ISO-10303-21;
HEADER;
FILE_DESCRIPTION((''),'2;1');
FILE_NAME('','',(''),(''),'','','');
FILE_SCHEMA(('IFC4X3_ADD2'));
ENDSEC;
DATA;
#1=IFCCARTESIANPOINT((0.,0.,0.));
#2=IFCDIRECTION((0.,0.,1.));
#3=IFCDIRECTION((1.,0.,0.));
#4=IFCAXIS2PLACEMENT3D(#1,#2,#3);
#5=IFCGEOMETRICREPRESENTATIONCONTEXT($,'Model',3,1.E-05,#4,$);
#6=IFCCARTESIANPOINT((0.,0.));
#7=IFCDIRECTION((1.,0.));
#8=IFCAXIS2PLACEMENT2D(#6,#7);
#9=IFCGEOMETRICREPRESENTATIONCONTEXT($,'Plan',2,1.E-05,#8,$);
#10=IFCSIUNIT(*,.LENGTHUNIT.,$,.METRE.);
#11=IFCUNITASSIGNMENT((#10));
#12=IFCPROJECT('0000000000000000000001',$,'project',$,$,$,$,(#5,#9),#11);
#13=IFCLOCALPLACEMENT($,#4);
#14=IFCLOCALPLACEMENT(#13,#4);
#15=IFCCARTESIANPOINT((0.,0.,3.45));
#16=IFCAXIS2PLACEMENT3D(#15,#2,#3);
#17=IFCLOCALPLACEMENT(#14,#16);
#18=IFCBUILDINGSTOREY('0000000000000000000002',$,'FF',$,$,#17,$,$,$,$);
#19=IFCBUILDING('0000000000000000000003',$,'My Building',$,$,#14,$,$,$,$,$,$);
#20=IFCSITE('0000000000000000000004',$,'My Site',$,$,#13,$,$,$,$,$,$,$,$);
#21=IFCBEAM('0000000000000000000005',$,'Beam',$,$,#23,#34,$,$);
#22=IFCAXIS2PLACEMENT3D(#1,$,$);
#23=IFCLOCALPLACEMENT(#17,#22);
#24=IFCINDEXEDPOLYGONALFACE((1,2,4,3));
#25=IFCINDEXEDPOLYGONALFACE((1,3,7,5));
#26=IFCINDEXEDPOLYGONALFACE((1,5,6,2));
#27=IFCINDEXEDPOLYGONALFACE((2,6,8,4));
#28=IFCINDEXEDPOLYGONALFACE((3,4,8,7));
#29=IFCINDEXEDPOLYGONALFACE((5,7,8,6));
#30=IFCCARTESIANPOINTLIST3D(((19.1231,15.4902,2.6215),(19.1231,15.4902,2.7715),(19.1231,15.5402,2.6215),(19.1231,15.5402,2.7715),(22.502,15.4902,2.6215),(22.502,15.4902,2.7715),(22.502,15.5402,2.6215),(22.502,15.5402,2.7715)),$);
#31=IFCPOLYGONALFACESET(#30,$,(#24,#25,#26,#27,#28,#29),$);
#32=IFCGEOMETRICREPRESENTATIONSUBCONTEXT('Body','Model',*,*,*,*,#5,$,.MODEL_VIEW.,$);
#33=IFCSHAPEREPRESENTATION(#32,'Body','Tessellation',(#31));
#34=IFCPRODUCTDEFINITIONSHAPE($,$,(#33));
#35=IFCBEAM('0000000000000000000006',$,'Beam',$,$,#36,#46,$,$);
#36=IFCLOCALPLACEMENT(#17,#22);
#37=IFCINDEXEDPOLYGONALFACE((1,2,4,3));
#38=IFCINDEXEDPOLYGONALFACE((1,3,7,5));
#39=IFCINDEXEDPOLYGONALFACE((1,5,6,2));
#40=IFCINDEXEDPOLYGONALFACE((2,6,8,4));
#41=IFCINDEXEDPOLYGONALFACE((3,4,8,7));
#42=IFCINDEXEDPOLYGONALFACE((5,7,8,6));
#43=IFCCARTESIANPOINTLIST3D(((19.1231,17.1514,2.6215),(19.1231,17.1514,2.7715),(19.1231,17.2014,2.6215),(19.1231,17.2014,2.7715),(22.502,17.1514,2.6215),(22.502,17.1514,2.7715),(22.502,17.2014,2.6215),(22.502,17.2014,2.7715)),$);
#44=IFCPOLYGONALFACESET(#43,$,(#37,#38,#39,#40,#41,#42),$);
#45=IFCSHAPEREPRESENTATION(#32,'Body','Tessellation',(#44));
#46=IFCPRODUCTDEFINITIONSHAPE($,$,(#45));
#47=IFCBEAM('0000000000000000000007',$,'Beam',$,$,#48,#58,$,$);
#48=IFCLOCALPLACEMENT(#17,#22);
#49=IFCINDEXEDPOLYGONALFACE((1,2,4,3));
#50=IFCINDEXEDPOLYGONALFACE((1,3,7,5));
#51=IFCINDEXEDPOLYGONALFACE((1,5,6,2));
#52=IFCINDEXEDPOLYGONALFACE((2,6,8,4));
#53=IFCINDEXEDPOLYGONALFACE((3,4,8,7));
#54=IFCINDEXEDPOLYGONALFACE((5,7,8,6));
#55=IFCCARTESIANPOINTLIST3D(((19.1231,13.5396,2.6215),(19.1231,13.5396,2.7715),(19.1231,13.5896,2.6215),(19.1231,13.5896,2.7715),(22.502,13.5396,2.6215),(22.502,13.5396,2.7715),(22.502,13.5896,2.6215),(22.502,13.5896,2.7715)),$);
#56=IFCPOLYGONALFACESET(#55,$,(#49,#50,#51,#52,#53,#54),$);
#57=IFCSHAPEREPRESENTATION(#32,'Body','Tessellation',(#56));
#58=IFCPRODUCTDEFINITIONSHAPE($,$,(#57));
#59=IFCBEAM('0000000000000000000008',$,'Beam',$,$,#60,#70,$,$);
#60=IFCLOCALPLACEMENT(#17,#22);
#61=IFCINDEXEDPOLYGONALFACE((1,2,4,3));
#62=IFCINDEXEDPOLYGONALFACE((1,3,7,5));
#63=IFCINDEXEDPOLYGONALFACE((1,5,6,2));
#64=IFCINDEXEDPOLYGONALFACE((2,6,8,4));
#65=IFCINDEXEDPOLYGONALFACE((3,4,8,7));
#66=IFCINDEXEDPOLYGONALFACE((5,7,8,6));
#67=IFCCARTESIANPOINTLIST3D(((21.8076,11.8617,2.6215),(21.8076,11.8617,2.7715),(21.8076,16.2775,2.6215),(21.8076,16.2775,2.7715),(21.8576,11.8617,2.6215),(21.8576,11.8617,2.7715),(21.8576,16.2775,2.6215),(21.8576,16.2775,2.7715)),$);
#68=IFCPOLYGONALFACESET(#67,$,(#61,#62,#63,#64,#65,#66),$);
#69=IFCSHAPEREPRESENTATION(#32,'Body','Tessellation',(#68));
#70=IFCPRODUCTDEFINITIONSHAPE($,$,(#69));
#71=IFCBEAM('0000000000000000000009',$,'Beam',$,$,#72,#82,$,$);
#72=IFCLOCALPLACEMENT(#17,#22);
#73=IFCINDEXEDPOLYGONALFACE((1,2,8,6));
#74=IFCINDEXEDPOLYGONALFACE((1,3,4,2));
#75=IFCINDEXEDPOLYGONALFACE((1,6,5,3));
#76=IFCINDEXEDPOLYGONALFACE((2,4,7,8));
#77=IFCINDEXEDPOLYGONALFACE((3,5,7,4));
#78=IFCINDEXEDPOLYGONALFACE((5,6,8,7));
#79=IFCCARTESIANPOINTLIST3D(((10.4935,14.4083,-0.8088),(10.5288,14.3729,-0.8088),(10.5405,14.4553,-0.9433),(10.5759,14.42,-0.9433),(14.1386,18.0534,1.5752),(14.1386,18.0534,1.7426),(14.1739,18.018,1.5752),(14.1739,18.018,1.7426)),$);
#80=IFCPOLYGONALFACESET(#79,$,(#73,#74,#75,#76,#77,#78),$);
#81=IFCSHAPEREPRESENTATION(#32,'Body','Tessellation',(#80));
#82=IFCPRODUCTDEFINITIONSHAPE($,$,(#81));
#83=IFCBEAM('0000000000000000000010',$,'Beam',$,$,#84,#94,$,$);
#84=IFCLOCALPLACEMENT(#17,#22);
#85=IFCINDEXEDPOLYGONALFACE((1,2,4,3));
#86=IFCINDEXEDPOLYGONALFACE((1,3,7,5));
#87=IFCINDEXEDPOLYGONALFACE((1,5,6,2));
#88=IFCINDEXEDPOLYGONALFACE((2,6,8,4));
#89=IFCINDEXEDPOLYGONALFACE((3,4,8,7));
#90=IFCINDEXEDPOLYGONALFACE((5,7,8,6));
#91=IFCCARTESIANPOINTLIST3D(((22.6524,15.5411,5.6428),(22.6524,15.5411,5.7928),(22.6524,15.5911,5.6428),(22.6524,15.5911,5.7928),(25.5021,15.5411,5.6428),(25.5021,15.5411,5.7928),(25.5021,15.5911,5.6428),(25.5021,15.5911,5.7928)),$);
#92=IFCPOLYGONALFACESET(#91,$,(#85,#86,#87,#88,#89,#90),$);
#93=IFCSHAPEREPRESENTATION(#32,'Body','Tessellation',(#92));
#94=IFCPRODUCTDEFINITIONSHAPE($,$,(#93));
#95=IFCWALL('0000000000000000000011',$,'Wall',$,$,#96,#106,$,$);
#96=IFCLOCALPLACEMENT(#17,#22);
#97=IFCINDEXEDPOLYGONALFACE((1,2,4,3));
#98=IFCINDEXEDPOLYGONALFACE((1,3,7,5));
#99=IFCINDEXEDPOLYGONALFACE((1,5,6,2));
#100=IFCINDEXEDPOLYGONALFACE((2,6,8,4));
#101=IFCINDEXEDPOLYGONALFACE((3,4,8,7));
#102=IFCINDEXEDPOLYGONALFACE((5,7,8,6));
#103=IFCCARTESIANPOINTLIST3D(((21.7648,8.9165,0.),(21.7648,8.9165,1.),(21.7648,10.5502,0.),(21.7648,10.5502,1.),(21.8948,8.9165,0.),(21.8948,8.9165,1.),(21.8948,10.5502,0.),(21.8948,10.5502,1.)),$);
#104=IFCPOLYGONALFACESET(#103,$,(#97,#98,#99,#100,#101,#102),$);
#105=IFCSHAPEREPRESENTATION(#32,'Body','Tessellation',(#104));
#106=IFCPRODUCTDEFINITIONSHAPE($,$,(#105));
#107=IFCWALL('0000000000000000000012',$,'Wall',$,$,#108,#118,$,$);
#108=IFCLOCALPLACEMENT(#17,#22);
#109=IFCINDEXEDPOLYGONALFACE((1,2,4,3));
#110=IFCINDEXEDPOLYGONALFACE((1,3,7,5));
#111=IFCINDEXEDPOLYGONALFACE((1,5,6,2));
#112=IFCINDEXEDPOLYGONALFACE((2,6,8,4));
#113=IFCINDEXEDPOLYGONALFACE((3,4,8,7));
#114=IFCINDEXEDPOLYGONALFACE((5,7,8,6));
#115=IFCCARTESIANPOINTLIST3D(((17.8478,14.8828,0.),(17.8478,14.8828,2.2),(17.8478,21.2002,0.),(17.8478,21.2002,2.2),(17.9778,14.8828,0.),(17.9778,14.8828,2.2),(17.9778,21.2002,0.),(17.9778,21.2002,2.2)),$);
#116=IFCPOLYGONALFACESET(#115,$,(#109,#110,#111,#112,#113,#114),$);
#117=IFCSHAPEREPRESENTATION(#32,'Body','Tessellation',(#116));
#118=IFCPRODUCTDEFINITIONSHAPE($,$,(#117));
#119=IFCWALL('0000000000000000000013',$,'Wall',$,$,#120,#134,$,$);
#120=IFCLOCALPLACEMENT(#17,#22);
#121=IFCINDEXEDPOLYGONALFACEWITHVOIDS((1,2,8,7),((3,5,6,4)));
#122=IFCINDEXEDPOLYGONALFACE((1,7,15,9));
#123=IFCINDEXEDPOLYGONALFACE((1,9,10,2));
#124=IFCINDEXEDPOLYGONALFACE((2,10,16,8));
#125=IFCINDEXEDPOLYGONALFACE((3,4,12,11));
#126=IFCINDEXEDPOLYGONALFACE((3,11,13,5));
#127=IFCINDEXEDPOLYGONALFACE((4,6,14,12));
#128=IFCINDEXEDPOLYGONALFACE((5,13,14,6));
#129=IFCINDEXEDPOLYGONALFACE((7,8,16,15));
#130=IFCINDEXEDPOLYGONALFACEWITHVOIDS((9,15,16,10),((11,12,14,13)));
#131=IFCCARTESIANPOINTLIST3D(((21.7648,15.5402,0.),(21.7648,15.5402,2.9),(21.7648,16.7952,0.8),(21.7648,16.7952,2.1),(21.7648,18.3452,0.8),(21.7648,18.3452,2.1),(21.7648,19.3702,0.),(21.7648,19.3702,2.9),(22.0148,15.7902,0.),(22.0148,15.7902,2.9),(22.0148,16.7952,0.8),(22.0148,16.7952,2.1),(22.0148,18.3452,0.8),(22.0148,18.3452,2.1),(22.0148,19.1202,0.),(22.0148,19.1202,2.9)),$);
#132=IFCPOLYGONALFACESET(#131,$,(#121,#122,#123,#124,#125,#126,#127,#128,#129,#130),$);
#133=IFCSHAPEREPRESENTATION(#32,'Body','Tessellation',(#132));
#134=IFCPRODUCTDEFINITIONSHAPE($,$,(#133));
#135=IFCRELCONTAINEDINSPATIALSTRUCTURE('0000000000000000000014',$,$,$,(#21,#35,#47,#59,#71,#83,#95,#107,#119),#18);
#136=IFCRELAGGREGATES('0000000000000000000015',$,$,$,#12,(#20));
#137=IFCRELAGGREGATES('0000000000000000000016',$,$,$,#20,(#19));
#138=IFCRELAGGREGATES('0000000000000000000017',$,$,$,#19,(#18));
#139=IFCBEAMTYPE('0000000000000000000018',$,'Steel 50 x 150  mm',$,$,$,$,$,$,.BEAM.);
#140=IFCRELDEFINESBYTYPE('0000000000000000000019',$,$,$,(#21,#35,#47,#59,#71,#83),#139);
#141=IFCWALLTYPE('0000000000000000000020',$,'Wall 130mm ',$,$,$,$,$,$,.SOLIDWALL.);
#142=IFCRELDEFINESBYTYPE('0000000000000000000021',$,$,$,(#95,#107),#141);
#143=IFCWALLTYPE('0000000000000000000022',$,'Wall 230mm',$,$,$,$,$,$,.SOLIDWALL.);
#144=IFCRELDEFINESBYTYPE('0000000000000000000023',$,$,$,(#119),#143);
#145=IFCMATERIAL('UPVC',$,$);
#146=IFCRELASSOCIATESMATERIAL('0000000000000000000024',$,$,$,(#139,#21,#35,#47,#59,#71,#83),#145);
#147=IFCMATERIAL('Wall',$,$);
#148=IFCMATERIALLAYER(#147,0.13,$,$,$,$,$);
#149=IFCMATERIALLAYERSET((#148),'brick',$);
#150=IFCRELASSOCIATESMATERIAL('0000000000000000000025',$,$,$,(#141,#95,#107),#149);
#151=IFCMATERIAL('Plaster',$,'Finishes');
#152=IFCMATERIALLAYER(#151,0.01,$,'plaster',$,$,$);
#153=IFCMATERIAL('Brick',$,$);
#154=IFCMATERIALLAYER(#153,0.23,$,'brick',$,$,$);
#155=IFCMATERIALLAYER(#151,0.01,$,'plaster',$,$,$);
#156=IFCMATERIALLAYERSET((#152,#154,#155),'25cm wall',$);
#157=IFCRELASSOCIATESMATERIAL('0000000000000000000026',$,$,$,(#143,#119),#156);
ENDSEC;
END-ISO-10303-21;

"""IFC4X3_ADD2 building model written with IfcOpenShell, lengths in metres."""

from ifc_helpers import new_model, si_unit, frame, origin_with_axes, origin_2d_with_axis, place, context, subcontext, project, spatial, line, indexed_curve, rectangle, outline, extrude, clip, halfspace, source, transform, mapped, material, layer, layer_set, layer_usage, material_profile, profile_set, profile_usage, type_object, element, save


model = new_model("IFC4X3_ADD2")

# Units and contexts
model_context = context("Model", 3, precision=1e-05, world=origin_with_axes())
plan_context = context("Plan", 2, precision=1e-05, world=origin_2d_with_axis())
body_context = subcontext(model_context, "Body", "Model", "MODEL_VIEW")
ifc_project = project(units=[si_unit("LENGTHUNIT", "METRE")], contexts=[model_context, plan_context])

# Site, building, storey
site_placement = place(None, origin_with_axes())
site = spatial("IfcSite", under=ifc_project, at=site_placement, Name="My Site")
building_placement = place(site_placement, origin_with_axes())
building = spatial("IfcBuilding", under=site, at=building_placement, Name="My Building")
storey_placement = place(building_placement, frame((0.0, 0.0, 3.45), z_axis=(0.0, 0.0, 1.0), x_axis=(1.0, 0.0, 0.0)))
storey = spatial("IfcBuildingStorey", under=building, at=storey_placement, Name="FF")

# Beams
ifc_material_1 = material(Name="UPVC")
ifc_material_profile = material_profile(ifc_material_1, rectangle(XDim=0.05, YDim=0.15))
ifc_profile_set = profile_set([ifc_material_profile])
beam_type = type_object("IfcBeamType", Name="Steel 50 x 150  mm", PredefinedType="BEAM", material=ifc_profile_set)
ifc_profile_usage_1 = profile_usage(ifc_profile_set)
beam_1_placement = place(storey_placement, frame((19.1231, 15.5152, 2.6965), z_axis=(1.0, 0.0, 0.0), x_axis=(0.0, 1.0, 0.0)))
element("IfcBeam", 1, at=beam_1_placement, inside=storey, type_object=beam_type, material=ifc_profile_usage_1, Name="Beam", context=body_context, shape_type="SweptSolid", body=[
    extrude(rectangle(XDim=0.05, YDim=0.15), origin_with_axes(), (0.0, 0.0, 1.0), 3.3789),
])
ifc_profile_usage_2 = profile_usage(ifc_profile_set)
beam_2_placement = place(storey_placement, frame((19.1231, 17.1764, 2.6965), z_axis=(1.0, 0.0, 0.0), x_axis=(0.0, 1.0, 0.0)))
element("IfcBeam", 2, at=beam_2_placement, inside=storey, type_object=beam_type, material=ifc_profile_usage_2, Name="Beam", context=body_context, shape_type="SweptSolid", body=[
    extrude(rectangle(XDim=0.05, YDim=0.15), origin_with_axes(), (0.0, 0.0, 1.0), 3.3789),
])
ifc_profile_usage_3 = profile_usage(ifc_profile_set)
beam_3_placement = place(storey_placement, frame((19.1231, 13.5646, 2.6965), z_axis=(1.0, 0.0, 0.0), x_axis=(0.0, 1.0, 0.0)))
element("IfcBeam", 3, at=beam_3_placement, inside=storey, type_object=beam_type, material=ifc_profile_usage_3, Name="Beam", context=body_context, shape_type="SweptSolid", body=[
    extrude(rectangle(XDim=0.05, YDim=0.15), origin_with_axes(), (0.0, 0.0, 1.0), 3.3789),
])
ifc_profile_usage_4 = profile_usage(ifc_profile_set)
beam_4_placement = place(storey_placement, frame((21.8326, 11.8617, 2.6965), z_axis=(0.0, 1.0, 0.0), x_axis=(-1.0, 0.0, 0.0)))
element("IfcBeam", 4, at=beam_4_placement, inside=storey, type_object=beam_type, material=ifc_profile_usage_4, Name="Beam", context=body_context, shape_type="SweptSolid", body=[
    extrude(rectangle(XDim=0.05, YDim=0.15), origin_with_axes(), (0.0, 0.0, 1.0), 4.4158),
])
ifc_profile_usage_5 = profile_usage(ifc_profile_set)
beam_5_placement = place(storey_placement, frame((10.5347, 14.4141, -0.8761), z_axis=(0.63373, 0.633729, 0.443593), x_axis=(-0.707106, 0.707107, 0.0)))
element("IfcBeam", 5, at=beam_5_placement, inside=storey, type_object=beam_type, material=ifc_profile_usage_5, Name="Beam", context=body_context, shape_type="Clipping", body=[
    clip(extrude(rectangle(XDim=0.05, YDim=0.15), origin_with_axes(), (0.0, 0.0, 1.0), 5.8647), halfspace(frame((5.1339, -2.2719, 4.5902), z_axis=(0.0, -0.443593, 0.896229), x_axis=(-1.0, 0.0, 0.0)), False)),
])
ifc_profile_usage_6 = profile_usage(ifc_profile_set)
beam_6_placement = place(storey_placement, frame((22.6524, 15.5661, 5.7178), z_axis=(1.0, 0.0, 0.0), x_axis=(0.0, 1.0, 0.0)))
element("IfcBeam", 6, at=beam_6_placement, inside=storey, type_object=beam_type, material=ifc_profile_usage_6, Name="Beam", context=body_context, shape_type="SweptSolid", body=[
    extrude(rectangle(XDim=0.05, YDim=0.15), origin_with_axes(), (0.0, 0.0, 1.0), 2.8497),
])

# Walls
ifc_material_2 = material(Name="Wall")
ifc_layer_1 = layer(ifc_material_2, 0.13)
ifc_layer_set_1 = layer_set([ifc_layer_1], Name="brick")
ifc_layer_usage_1 = layer_usage(ifc_layer_set_1, "AXIS2", "POSITIVE", 0.0)
wall_type_1 = type_object("IfcWallType", Name="Wall 130mm ", PredefinedType="SOLIDWALL", material=ifc_layer_set_1)
wall_1_placement = place(storey_placement, frame((21.7648, 10.5502, 0.0), z_axis=(0.0, 0.0, 1.0), x_axis=(0.0, -1.0, 0.0)))
element("IfcWall", 7, at=wall_1_placement, inside=storey, type_object=wall_type_1, material=ifc_layer_usage_1, Name="Wall", context=body_context, shape_type="SweptSolid", body=[
    extrude(outline(indexed_curve([(0.0, 0.0), (0.0, 0.13), (1.6337, 0.13), (1.6337, 0.0), (0.0, 0.0)], self_intersect=False)), origin_with_axes(), (0.0, 0.0, 1.0), 1.0),
])
ifc_layer_usage_2 = layer_usage(ifc_layer_set_1, "AXIS2", "POSITIVE", 0.0)
wall_2_placement = place(storey_placement, frame((17.9778, 14.8828, 0.0), z_axis=(0.0, 0.0, 1.0), x_axis=(0.000001, 1.0, 0.0)))
element("IfcWall", 8, at=wall_2_placement, inside=storey, type_object=wall_type_1, material=ifc_layer_usage_2, Name="Wall", context=body_context, shape_type="SweptSolid", body=[
    extrude(outline(indexed_curve([(0.0, 0.0), (0.0, 0.13), (6.3175, 0.13), (6.3175, 0.0), (0.0, 0.0)], self_intersect=False)), origin_with_axes(), (0.0, 0.0, 1.0), 2.2),
])

# Wall, opening
ifc_material_3 = material(Name="Plaster", Category="Finishes")
ifc_layer_2 = layer(ifc_material_3, 0.01, Name="plaster")
ifc_material_4 = material(Name="Brick")
ifc_layer_3 = layer(ifc_material_4, 0.23, Name="brick")
ifc_layer_4 = layer(ifc_material_3, 0.01, Name="plaster")
ifc_layer_set_2 = layer_set([ifc_layer_2, ifc_layer_3, ifc_layer_4], Name="25cm wall")
ifc_layer_usage_3 = layer_usage(ifc_layer_set_2, "AXIS2", "NEGATIVE", 0.0)
wall_type_2 = type_object("IfcWallType", Name="Wall 230mm", PredefinedType="SOLIDWALL", material=ifc_layer_set_2)
wall_3_placement = place(storey_placement, frame((21.7648, 15.5402, 0.0), z_axis=(0.0, 0.0, 1.0), x_axis=(0.000001, 1.0, 0.0)))
wall_3 = element("IfcWall", 9, at=wall_3_placement, inside=storey, type_object=wall_type_2, material=ifc_layer_usage_3, Name="Wall", context=body_context, shape_type="SweptSolid", body=[
    extrude(outline(indexed_curve([(0.25, -0.25), (0.0, 0.0), (3.83, 0.0), (3.58, -0.25)], segments=[line(1, 2, 3, 4, 1)])), origin_with_axes(), (0.0, 0.0, 1.0), 2.9),
])
shared_shape = source(origin_with_axes(), body_context, "Body", "SweptSolid", [
    extrude(outline(indexed_curve([(0.0, 0.0), (1.55, 0.0), (1.55, 1.3), (0.0, 1.3)], segments=[line(1, 2, 3, 4, 1)])), frame((-0.775, -0.6, 0.0), z_axis=(0.0, -1.0, 0.0), x_axis=(1.0, 0.0, 0.0)), (0.0, 0.0, -1.0), 1.2),
])
opening_placement = place(wall_3_placement, frame((2.03, 0.0, 0.8), z_axis=(0.0, 0.0, 1.0), x_axis=(1.0, 0.0, 0.0)))
element("IfcOpeningElement", 10, at=opening_placement, cuts=wall_3, PredefinedType="OPENING", context=body_context, shape_type="MappedRepresentation", body=[
    mapped(shared_shape, transform((0.0, 0.0, 0.0), x_axis=(1.0, 0.0, 0.0), y_axis=(0.0, 1.0, 0.0), z_axis=(0.0, 0.0, 1.0), scale=1.0)),
])

save(model, "model.ifc")
